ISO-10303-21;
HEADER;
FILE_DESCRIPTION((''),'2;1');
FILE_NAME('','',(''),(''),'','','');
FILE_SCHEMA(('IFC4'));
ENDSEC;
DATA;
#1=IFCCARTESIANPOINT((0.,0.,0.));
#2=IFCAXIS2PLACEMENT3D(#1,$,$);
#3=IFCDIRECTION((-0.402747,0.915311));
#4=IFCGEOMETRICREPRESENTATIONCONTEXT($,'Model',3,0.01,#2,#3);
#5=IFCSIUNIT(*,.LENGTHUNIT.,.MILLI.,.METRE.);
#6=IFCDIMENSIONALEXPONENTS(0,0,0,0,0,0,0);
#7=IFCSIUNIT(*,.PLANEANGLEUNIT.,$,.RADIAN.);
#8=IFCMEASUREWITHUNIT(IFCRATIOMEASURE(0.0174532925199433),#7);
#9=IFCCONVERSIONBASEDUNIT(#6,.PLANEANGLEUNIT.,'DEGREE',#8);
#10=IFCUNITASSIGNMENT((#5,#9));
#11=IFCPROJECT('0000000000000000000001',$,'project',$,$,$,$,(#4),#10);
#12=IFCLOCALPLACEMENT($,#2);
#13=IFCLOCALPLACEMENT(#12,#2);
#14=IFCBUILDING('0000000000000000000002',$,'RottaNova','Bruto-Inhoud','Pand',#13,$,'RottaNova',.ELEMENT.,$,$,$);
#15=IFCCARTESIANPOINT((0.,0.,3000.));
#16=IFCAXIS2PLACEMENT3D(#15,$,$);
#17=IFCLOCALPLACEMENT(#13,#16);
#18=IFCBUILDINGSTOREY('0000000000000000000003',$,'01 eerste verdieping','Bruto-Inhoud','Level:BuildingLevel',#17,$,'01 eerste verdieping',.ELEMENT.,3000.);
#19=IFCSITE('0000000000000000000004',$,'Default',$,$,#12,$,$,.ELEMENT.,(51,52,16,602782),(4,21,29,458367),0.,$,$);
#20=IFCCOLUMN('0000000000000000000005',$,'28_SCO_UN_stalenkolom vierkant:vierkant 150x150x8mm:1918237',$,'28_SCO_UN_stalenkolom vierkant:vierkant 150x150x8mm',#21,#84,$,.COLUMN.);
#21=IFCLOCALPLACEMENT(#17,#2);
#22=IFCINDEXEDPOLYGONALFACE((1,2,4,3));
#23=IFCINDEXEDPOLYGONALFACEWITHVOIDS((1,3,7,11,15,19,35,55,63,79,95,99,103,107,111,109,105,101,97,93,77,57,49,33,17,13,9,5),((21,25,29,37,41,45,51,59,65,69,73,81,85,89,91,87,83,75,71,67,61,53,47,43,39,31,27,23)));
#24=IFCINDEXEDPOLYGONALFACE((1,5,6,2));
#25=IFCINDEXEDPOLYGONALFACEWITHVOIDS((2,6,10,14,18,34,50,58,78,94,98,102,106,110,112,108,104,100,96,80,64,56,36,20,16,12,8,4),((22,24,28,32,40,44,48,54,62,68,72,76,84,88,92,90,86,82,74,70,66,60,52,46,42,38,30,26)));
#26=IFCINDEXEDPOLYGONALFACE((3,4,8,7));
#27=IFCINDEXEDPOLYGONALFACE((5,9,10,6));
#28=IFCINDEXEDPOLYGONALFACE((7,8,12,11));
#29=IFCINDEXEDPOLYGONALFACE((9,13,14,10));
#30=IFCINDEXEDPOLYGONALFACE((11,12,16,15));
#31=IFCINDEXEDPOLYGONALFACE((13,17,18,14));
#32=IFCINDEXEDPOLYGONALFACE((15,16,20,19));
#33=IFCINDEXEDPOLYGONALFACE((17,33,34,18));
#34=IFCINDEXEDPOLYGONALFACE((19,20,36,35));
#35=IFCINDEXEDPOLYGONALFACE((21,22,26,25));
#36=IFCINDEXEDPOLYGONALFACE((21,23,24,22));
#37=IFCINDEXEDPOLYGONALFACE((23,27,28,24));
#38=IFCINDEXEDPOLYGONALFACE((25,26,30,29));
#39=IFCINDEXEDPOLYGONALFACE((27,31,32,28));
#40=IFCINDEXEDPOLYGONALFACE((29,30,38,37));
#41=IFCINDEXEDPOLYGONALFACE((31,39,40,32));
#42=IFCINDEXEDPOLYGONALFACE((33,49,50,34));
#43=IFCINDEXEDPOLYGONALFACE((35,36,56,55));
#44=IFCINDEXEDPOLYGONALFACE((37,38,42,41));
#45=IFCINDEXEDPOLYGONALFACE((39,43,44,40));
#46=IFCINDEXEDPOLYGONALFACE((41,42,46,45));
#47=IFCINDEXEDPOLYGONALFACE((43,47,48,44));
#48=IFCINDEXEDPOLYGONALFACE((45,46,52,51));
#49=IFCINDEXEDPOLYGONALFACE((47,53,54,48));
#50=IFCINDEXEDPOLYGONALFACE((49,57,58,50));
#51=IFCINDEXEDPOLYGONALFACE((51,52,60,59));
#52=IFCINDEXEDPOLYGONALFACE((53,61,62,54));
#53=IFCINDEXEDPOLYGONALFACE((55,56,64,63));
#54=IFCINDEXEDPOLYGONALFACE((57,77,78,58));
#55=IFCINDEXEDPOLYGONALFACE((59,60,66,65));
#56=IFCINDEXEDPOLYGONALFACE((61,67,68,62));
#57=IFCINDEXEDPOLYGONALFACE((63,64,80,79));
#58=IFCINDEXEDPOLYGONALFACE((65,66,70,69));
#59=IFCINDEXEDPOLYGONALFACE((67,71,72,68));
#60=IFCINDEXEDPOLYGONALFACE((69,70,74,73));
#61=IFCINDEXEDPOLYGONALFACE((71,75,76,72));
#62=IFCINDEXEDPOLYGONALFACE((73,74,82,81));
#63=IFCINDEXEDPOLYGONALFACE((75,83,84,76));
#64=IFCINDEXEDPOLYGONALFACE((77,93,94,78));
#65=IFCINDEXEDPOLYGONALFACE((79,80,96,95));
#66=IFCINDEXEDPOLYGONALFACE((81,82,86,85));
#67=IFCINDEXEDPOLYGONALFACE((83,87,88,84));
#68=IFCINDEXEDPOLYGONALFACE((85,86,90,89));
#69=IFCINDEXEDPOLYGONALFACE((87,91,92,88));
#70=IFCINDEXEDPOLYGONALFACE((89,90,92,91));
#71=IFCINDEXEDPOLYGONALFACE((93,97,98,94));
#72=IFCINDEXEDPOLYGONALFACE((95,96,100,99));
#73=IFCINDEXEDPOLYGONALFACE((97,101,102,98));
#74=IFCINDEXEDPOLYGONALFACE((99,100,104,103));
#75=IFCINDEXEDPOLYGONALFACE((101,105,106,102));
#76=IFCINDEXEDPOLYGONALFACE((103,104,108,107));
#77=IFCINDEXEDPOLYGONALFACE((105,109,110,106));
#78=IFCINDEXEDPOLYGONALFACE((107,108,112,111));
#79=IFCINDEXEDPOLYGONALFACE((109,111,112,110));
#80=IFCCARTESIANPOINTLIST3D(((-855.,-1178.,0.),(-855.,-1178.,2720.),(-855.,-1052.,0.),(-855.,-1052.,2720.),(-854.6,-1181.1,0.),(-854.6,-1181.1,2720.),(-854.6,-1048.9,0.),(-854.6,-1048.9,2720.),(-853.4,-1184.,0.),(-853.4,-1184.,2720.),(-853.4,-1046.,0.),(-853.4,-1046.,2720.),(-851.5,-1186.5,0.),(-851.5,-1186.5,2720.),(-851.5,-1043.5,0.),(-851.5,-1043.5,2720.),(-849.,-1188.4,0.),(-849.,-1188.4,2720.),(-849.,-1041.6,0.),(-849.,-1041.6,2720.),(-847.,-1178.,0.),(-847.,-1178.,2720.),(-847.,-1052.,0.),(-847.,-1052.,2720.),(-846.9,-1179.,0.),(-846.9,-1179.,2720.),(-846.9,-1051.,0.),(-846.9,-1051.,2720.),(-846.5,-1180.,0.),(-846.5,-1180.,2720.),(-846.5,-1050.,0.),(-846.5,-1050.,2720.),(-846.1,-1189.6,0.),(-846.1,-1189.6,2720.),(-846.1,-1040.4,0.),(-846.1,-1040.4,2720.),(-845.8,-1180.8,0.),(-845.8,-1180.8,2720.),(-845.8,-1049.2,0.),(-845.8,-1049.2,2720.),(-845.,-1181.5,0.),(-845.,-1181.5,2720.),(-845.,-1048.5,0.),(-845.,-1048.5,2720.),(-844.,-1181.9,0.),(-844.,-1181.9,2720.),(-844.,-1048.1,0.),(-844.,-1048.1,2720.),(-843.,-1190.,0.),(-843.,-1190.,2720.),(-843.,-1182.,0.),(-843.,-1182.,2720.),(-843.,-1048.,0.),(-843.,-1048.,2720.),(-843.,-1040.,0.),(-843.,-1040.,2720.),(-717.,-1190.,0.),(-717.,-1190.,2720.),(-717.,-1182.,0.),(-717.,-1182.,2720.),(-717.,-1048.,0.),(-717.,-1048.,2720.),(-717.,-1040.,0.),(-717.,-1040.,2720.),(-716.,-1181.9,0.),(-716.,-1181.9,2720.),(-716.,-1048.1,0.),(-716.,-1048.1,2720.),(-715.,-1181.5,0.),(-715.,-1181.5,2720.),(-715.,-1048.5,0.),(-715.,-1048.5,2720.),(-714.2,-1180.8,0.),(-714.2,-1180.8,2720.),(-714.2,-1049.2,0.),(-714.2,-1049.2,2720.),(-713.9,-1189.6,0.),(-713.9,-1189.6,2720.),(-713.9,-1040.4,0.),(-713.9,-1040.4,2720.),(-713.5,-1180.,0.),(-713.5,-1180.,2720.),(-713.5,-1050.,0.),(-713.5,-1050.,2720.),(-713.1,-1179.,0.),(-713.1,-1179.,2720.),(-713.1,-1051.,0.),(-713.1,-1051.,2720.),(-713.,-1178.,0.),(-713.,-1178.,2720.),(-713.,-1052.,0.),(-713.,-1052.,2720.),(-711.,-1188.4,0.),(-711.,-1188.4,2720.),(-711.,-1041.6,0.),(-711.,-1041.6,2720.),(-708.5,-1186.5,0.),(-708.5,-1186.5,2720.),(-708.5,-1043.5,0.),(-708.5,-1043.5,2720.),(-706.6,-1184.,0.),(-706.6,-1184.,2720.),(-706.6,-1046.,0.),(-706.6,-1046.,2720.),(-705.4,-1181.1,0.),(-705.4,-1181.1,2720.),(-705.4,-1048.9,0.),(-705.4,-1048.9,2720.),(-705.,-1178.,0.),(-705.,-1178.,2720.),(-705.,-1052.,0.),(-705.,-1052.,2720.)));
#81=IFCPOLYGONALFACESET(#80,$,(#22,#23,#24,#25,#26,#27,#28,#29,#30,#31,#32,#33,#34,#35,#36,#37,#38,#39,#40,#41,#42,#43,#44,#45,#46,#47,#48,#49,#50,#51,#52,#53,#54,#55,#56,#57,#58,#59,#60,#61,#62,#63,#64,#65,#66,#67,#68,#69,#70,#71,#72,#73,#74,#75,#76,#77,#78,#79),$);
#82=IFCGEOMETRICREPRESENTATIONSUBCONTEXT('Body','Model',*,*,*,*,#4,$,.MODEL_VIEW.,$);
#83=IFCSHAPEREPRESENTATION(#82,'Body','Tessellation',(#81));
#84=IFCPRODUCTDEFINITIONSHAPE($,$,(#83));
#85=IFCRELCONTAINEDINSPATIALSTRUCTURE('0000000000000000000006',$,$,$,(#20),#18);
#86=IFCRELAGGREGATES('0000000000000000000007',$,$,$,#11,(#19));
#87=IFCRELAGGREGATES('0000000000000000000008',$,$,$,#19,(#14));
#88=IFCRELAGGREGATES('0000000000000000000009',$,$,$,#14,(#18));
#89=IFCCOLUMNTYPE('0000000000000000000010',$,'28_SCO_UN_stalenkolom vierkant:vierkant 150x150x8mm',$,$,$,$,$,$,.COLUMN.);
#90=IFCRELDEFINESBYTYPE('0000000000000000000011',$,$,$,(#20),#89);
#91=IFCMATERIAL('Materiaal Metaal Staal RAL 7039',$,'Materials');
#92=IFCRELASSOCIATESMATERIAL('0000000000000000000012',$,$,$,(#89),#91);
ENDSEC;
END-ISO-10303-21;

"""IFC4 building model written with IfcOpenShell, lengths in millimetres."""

from ifc_helpers import new_model, entity, si_unit, converted_unit, direction, frame, frame_2d, origin, place, context, subcontext, project, spatial, polyline, circle_curve, parameter, trimmed, segment, composite_curve, outline, extrude, source, transform, mapped, material, material_profile, profile_set, type_object, type_shapes, element, save


model = new_model("IFC4")

# Units and contexts
model_context = context("Model", 3, precision=0.01, world=origin(), true_north=direction((-0.402747, 0.915311)))
body_context = subcontext(model_context, "Body", "Model", "MODEL_VIEW")
ifc_project = project(units=[si_unit("LENGTHUNIT", "METRE", prefix="MILLI"), converted_unit("PLANEANGLEUNIT", "DEGREE", entity("IfcRatioMeasure", 0.0174532925199433), si_unit("PLANEANGLEUNIT", "RADIAN"), dimensions=[0, 0, 0, 0, 0, 0, 0])], contexts=[model_context])

# Site, building, storey
site_placement = place(None, origin())
site = spatial("IfcSite", under=ifc_project, at=site_placement, Name="Default", CompositionType="ELEMENT", RefLatitude=(51, 52, 16, 602782), RefLongitude=(4, 21, 29, 458367), RefElevation=0.0)
building_placement = place(site_placement, origin())
building = spatial("IfcBuilding", under=site, at=building_placement, Name="RottaNova", Description="Bruto-Inhoud", ObjectType="Pand", LongName="RottaNova", CompositionType="ELEMENT")
storey_placement = place(building_placement, frame((0.0, 0.0, 3000.0)))
storey = spatial("IfcBuildingStorey", under=building, at=storey_placement, Name="01 eerste verdieping", Description="Bruto-Inhoud", ObjectType="Level:BuildingLevel", LongName="01 eerste verdieping", CompositionType="ELEMENT", Elevation=3000.0)

# Column
ifc_material_1 = material(Name="Materiaal Metaal Staal RAL 7039", Category="Materials")
ifc_material_profile = material_profile(ifc_material_1, outline(composite_curve([segment(trimmed(circle_curve(frame_2d((63.0, -63.0), x_axis=(1.0, 0.0)), 12.0), [parameter(270.0)], [parameter(360.0)], True, "PARAMETER"), True, "CONTINUOUS"), segment(polyline([(75.0, -63.0), (75.0, 63.0)]), True, "CONTINUOUS"), segment(trimmed(circle_curve(frame_2d((63.0, 63.0), x_axis=(1.0, 0.0)), 12.0), [parameter(360.0)], [parameter(90.0)], True, "PARAMETER"), True, "CONTINUOUS"), segment(polyline([(63.0, 75.0), (-63.0, 75.0)]), True, "CONTINUOUS"), segment(trimmed(circle_curve(frame_2d((-63.0, 63.0), x_axis=(1.0, 0.0)), 12.0), [parameter(90.0)], [parameter(180.0)], True, "PARAMETER"), True, "CONTINUOUS"), segment(polyline([(-75.0, 63.0), (-75.0, -63.0)]), True, "CONTINUOUS"), segment(trimmed(circle_curve(frame_2d((-63.0, -63.0), x_axis=(1.0, 0.0)), 12.0), [parameter(180.0)], [parameter(270.0)], True, "PARAMETER"), True, "CONTINUOUS"), segment(polyline([(-63.0, -75.0), (63.0, -75.0)]), True, "CONTINUOUS")], self_intersect=False), holes=[composite_curve([segment(polyline([(-67.0, -63.0), (-67.0, 63.0)]), True, "CONTINUOUS"), segment(trimmed(circle_curve(frame_2d((-63.0, 63.0), x_axis=(1.0, 0.0)), 4.0), [parameter(90.0)], [parameter(180.0)], True, "PARAMETER"), False, "CONTINUOUS"), segment(polyline([(-63.0, 67.0), (63.0, 67.0)]), True, "CONTINUOUS"), segment(trimmed(circle_curve(frame_2d((63.0, 63.0), x_axis=(1.0, 0.0)), 4.0), [parameter(0.0)], [parameter(90.0)], True, "PARAMETER"), False, "CONTINUOUS"), segment(polyline([(67.0, 63.0), (67.0, -63.0)]), True, "CONTINUOUS"), segment(trimmed(circle_curve(frame_2d((63.0, -63.0), x_axis=(1.0, 0.0)), 4.0), [parameter(270.0)], [parameter(0.0)], True, "PARAMETER"), False, "CONTINUOUS"), segment(polyline([(63.0, -67.0), (-63.0, -67.0)]), True, "CONTINUOUS"), segment(trimmed(circle_curve(frame_2d((-63.0, -63.0), x_axis=(1.0, 0.0)), 4.0), [parameter(180.0)], [parameter(270.0)], True, "PARAMETER"), False, "CONTINUOUS")], self_intersect=False)]), Name="vierkant 150x150x8mm")
ifc_profile_set = profile_set([ifc_material_profile], Name="vierkant 150x150x8mm")
column_type = type_object("IfcColumnType", Name="28_SCO_UN_stalenkolom vierkant:vierkant 150x150x8mm", PredefinedType="COLUMN", material=ifc_profile_set)
shared_shape = source(origin(), body_context, "Body", "SweptSolid", [
    extrude(outline(composite_curve([segment(polyline([(-63.0, -75.0), (63.0, -75.0)]), True, "CONTINUOUS"), segment(trimmed(circle_curve(frame_2d((63.0, -63.0), x_axis=(-1.0, 0.0)), 12.0), [parameter(90.0)], [parameter(180.0)], True, "PARAMETER"), True, "CONTINUOUS"), segment(polyline([(75.0, -63.0), (75.0, 63.0)]), True, "CONTINUOUS"), segment(trimmed(circle_curve(frame_2d((63.0, 63.0), x_axis=(-1.0, 0.0)), 12.0), [parameter(180.0)], [parameter(270.0)], True, "PARAMETER"), True, "CONTINUOUS"), segment(polyline([(63.0, 75.0), (-63.0, 75.0)]), True, "CONTINUOUS"), segment(trimmed(circle_curve(frame_2d((-63.0, 63.0), x_axis=(-1.0, 0.0)), 12.0), [parameter(270.0)], [parameter(0.0)], True, "PARAMETER"), True, "CONTINUOUS"), segment(polyline([(-75.0, 63.0), (-75.0, -63.0)]), True, "CONTINUOUS"), segment(trimmed(circle_curve(frame_2d((-63.0, -63.0), x_axis=(-1.0, 0.0)), 12.0), [parameter(0.0)], [parameter(90.0)], True, "PARAMETER"), True, "CONTINUOUS")], self_intersect=False), holes=[composite_curve([segment(trimmed(circle_curve(frame_2d((63.0, -63.0), x_axis=(-1.0, 0.0)), 4.0), [parameter(90.0)], [parameter(180.0)], True, "PARAMETER"), False, "CONTINUOUS"), segment(polyline([(63.0, -67.0), (-63.0, -67.0)]), True, "CONTINUOUS"), segment(trimmed(circle_curve(frame_2d((-63.0, -63.0), x_axis=(-1.0, 0.0)), 4.0), [parameter(0.0)], [parameter(90.0)], True, "PARAMETER"), False, "CONTINUOUS"), segment(polyline([(-67.0, -63.0), (-67.0, 63.0)]), True, "CONTINUOUS"), segment(trimmed(circle_curve(frame_2d((-63.0, 63.0), x_axis=(-1.0, 0.0)), 4.0), [parameter(270.0)], [parameter(360.0)], True, "PARAMETER"), False, "CONTINUOUS"), segment(polyline([(-63.0, 67.0), (63.0, 67.0)]), True, "CONTINUOUS"), segment(trimmed(circle_curve(frame_2d((63.0, 63.0), x_axis=(-1.0, 0.0)), 4.0), [parameter(180.0)], [parameter(270.0)], True, "PARAMETER"), False, "CONTINUOUS"), segment(polyline([(67.0, 63.0), (67.0, -63.0)]), True, "CONTINUOUS")], self_intersect=False)]), frame((76.6, 76.6, 0.0), z_axis=(0.0, 0.0, 1.0), x_axis=(-1.0, 0.0, 0.0)), (0.0, 0.0, 1.0), 2720.0),
])
type_shapes(column_type, [shared_shape])
column_placement = place(storey_placement, frame((-703.4, -1038.4, 0.0), z_axis=(0.0, 0.0, 1.0), x_axis=(-1.0, 0.0, 0.0)))
element("IfcColumn", 1, at=column_placement, inside=storey, type_object=column_type, Name="28_SCO_UN_stalenkolom vierkant:vierkant 150x150x8mm:1918237", ObjectType="28_SCO_UN_stalenkolom vierkant:vierkant 150x150x8mm", PredefinedType="COLUMN", context=body_context, shape_type="MappedRepresentation", body=[
    mapped(shared_shape, transform((0.0, 0.0, 0.0), scale=1.0)),
])

save(model, "model.ifc")
